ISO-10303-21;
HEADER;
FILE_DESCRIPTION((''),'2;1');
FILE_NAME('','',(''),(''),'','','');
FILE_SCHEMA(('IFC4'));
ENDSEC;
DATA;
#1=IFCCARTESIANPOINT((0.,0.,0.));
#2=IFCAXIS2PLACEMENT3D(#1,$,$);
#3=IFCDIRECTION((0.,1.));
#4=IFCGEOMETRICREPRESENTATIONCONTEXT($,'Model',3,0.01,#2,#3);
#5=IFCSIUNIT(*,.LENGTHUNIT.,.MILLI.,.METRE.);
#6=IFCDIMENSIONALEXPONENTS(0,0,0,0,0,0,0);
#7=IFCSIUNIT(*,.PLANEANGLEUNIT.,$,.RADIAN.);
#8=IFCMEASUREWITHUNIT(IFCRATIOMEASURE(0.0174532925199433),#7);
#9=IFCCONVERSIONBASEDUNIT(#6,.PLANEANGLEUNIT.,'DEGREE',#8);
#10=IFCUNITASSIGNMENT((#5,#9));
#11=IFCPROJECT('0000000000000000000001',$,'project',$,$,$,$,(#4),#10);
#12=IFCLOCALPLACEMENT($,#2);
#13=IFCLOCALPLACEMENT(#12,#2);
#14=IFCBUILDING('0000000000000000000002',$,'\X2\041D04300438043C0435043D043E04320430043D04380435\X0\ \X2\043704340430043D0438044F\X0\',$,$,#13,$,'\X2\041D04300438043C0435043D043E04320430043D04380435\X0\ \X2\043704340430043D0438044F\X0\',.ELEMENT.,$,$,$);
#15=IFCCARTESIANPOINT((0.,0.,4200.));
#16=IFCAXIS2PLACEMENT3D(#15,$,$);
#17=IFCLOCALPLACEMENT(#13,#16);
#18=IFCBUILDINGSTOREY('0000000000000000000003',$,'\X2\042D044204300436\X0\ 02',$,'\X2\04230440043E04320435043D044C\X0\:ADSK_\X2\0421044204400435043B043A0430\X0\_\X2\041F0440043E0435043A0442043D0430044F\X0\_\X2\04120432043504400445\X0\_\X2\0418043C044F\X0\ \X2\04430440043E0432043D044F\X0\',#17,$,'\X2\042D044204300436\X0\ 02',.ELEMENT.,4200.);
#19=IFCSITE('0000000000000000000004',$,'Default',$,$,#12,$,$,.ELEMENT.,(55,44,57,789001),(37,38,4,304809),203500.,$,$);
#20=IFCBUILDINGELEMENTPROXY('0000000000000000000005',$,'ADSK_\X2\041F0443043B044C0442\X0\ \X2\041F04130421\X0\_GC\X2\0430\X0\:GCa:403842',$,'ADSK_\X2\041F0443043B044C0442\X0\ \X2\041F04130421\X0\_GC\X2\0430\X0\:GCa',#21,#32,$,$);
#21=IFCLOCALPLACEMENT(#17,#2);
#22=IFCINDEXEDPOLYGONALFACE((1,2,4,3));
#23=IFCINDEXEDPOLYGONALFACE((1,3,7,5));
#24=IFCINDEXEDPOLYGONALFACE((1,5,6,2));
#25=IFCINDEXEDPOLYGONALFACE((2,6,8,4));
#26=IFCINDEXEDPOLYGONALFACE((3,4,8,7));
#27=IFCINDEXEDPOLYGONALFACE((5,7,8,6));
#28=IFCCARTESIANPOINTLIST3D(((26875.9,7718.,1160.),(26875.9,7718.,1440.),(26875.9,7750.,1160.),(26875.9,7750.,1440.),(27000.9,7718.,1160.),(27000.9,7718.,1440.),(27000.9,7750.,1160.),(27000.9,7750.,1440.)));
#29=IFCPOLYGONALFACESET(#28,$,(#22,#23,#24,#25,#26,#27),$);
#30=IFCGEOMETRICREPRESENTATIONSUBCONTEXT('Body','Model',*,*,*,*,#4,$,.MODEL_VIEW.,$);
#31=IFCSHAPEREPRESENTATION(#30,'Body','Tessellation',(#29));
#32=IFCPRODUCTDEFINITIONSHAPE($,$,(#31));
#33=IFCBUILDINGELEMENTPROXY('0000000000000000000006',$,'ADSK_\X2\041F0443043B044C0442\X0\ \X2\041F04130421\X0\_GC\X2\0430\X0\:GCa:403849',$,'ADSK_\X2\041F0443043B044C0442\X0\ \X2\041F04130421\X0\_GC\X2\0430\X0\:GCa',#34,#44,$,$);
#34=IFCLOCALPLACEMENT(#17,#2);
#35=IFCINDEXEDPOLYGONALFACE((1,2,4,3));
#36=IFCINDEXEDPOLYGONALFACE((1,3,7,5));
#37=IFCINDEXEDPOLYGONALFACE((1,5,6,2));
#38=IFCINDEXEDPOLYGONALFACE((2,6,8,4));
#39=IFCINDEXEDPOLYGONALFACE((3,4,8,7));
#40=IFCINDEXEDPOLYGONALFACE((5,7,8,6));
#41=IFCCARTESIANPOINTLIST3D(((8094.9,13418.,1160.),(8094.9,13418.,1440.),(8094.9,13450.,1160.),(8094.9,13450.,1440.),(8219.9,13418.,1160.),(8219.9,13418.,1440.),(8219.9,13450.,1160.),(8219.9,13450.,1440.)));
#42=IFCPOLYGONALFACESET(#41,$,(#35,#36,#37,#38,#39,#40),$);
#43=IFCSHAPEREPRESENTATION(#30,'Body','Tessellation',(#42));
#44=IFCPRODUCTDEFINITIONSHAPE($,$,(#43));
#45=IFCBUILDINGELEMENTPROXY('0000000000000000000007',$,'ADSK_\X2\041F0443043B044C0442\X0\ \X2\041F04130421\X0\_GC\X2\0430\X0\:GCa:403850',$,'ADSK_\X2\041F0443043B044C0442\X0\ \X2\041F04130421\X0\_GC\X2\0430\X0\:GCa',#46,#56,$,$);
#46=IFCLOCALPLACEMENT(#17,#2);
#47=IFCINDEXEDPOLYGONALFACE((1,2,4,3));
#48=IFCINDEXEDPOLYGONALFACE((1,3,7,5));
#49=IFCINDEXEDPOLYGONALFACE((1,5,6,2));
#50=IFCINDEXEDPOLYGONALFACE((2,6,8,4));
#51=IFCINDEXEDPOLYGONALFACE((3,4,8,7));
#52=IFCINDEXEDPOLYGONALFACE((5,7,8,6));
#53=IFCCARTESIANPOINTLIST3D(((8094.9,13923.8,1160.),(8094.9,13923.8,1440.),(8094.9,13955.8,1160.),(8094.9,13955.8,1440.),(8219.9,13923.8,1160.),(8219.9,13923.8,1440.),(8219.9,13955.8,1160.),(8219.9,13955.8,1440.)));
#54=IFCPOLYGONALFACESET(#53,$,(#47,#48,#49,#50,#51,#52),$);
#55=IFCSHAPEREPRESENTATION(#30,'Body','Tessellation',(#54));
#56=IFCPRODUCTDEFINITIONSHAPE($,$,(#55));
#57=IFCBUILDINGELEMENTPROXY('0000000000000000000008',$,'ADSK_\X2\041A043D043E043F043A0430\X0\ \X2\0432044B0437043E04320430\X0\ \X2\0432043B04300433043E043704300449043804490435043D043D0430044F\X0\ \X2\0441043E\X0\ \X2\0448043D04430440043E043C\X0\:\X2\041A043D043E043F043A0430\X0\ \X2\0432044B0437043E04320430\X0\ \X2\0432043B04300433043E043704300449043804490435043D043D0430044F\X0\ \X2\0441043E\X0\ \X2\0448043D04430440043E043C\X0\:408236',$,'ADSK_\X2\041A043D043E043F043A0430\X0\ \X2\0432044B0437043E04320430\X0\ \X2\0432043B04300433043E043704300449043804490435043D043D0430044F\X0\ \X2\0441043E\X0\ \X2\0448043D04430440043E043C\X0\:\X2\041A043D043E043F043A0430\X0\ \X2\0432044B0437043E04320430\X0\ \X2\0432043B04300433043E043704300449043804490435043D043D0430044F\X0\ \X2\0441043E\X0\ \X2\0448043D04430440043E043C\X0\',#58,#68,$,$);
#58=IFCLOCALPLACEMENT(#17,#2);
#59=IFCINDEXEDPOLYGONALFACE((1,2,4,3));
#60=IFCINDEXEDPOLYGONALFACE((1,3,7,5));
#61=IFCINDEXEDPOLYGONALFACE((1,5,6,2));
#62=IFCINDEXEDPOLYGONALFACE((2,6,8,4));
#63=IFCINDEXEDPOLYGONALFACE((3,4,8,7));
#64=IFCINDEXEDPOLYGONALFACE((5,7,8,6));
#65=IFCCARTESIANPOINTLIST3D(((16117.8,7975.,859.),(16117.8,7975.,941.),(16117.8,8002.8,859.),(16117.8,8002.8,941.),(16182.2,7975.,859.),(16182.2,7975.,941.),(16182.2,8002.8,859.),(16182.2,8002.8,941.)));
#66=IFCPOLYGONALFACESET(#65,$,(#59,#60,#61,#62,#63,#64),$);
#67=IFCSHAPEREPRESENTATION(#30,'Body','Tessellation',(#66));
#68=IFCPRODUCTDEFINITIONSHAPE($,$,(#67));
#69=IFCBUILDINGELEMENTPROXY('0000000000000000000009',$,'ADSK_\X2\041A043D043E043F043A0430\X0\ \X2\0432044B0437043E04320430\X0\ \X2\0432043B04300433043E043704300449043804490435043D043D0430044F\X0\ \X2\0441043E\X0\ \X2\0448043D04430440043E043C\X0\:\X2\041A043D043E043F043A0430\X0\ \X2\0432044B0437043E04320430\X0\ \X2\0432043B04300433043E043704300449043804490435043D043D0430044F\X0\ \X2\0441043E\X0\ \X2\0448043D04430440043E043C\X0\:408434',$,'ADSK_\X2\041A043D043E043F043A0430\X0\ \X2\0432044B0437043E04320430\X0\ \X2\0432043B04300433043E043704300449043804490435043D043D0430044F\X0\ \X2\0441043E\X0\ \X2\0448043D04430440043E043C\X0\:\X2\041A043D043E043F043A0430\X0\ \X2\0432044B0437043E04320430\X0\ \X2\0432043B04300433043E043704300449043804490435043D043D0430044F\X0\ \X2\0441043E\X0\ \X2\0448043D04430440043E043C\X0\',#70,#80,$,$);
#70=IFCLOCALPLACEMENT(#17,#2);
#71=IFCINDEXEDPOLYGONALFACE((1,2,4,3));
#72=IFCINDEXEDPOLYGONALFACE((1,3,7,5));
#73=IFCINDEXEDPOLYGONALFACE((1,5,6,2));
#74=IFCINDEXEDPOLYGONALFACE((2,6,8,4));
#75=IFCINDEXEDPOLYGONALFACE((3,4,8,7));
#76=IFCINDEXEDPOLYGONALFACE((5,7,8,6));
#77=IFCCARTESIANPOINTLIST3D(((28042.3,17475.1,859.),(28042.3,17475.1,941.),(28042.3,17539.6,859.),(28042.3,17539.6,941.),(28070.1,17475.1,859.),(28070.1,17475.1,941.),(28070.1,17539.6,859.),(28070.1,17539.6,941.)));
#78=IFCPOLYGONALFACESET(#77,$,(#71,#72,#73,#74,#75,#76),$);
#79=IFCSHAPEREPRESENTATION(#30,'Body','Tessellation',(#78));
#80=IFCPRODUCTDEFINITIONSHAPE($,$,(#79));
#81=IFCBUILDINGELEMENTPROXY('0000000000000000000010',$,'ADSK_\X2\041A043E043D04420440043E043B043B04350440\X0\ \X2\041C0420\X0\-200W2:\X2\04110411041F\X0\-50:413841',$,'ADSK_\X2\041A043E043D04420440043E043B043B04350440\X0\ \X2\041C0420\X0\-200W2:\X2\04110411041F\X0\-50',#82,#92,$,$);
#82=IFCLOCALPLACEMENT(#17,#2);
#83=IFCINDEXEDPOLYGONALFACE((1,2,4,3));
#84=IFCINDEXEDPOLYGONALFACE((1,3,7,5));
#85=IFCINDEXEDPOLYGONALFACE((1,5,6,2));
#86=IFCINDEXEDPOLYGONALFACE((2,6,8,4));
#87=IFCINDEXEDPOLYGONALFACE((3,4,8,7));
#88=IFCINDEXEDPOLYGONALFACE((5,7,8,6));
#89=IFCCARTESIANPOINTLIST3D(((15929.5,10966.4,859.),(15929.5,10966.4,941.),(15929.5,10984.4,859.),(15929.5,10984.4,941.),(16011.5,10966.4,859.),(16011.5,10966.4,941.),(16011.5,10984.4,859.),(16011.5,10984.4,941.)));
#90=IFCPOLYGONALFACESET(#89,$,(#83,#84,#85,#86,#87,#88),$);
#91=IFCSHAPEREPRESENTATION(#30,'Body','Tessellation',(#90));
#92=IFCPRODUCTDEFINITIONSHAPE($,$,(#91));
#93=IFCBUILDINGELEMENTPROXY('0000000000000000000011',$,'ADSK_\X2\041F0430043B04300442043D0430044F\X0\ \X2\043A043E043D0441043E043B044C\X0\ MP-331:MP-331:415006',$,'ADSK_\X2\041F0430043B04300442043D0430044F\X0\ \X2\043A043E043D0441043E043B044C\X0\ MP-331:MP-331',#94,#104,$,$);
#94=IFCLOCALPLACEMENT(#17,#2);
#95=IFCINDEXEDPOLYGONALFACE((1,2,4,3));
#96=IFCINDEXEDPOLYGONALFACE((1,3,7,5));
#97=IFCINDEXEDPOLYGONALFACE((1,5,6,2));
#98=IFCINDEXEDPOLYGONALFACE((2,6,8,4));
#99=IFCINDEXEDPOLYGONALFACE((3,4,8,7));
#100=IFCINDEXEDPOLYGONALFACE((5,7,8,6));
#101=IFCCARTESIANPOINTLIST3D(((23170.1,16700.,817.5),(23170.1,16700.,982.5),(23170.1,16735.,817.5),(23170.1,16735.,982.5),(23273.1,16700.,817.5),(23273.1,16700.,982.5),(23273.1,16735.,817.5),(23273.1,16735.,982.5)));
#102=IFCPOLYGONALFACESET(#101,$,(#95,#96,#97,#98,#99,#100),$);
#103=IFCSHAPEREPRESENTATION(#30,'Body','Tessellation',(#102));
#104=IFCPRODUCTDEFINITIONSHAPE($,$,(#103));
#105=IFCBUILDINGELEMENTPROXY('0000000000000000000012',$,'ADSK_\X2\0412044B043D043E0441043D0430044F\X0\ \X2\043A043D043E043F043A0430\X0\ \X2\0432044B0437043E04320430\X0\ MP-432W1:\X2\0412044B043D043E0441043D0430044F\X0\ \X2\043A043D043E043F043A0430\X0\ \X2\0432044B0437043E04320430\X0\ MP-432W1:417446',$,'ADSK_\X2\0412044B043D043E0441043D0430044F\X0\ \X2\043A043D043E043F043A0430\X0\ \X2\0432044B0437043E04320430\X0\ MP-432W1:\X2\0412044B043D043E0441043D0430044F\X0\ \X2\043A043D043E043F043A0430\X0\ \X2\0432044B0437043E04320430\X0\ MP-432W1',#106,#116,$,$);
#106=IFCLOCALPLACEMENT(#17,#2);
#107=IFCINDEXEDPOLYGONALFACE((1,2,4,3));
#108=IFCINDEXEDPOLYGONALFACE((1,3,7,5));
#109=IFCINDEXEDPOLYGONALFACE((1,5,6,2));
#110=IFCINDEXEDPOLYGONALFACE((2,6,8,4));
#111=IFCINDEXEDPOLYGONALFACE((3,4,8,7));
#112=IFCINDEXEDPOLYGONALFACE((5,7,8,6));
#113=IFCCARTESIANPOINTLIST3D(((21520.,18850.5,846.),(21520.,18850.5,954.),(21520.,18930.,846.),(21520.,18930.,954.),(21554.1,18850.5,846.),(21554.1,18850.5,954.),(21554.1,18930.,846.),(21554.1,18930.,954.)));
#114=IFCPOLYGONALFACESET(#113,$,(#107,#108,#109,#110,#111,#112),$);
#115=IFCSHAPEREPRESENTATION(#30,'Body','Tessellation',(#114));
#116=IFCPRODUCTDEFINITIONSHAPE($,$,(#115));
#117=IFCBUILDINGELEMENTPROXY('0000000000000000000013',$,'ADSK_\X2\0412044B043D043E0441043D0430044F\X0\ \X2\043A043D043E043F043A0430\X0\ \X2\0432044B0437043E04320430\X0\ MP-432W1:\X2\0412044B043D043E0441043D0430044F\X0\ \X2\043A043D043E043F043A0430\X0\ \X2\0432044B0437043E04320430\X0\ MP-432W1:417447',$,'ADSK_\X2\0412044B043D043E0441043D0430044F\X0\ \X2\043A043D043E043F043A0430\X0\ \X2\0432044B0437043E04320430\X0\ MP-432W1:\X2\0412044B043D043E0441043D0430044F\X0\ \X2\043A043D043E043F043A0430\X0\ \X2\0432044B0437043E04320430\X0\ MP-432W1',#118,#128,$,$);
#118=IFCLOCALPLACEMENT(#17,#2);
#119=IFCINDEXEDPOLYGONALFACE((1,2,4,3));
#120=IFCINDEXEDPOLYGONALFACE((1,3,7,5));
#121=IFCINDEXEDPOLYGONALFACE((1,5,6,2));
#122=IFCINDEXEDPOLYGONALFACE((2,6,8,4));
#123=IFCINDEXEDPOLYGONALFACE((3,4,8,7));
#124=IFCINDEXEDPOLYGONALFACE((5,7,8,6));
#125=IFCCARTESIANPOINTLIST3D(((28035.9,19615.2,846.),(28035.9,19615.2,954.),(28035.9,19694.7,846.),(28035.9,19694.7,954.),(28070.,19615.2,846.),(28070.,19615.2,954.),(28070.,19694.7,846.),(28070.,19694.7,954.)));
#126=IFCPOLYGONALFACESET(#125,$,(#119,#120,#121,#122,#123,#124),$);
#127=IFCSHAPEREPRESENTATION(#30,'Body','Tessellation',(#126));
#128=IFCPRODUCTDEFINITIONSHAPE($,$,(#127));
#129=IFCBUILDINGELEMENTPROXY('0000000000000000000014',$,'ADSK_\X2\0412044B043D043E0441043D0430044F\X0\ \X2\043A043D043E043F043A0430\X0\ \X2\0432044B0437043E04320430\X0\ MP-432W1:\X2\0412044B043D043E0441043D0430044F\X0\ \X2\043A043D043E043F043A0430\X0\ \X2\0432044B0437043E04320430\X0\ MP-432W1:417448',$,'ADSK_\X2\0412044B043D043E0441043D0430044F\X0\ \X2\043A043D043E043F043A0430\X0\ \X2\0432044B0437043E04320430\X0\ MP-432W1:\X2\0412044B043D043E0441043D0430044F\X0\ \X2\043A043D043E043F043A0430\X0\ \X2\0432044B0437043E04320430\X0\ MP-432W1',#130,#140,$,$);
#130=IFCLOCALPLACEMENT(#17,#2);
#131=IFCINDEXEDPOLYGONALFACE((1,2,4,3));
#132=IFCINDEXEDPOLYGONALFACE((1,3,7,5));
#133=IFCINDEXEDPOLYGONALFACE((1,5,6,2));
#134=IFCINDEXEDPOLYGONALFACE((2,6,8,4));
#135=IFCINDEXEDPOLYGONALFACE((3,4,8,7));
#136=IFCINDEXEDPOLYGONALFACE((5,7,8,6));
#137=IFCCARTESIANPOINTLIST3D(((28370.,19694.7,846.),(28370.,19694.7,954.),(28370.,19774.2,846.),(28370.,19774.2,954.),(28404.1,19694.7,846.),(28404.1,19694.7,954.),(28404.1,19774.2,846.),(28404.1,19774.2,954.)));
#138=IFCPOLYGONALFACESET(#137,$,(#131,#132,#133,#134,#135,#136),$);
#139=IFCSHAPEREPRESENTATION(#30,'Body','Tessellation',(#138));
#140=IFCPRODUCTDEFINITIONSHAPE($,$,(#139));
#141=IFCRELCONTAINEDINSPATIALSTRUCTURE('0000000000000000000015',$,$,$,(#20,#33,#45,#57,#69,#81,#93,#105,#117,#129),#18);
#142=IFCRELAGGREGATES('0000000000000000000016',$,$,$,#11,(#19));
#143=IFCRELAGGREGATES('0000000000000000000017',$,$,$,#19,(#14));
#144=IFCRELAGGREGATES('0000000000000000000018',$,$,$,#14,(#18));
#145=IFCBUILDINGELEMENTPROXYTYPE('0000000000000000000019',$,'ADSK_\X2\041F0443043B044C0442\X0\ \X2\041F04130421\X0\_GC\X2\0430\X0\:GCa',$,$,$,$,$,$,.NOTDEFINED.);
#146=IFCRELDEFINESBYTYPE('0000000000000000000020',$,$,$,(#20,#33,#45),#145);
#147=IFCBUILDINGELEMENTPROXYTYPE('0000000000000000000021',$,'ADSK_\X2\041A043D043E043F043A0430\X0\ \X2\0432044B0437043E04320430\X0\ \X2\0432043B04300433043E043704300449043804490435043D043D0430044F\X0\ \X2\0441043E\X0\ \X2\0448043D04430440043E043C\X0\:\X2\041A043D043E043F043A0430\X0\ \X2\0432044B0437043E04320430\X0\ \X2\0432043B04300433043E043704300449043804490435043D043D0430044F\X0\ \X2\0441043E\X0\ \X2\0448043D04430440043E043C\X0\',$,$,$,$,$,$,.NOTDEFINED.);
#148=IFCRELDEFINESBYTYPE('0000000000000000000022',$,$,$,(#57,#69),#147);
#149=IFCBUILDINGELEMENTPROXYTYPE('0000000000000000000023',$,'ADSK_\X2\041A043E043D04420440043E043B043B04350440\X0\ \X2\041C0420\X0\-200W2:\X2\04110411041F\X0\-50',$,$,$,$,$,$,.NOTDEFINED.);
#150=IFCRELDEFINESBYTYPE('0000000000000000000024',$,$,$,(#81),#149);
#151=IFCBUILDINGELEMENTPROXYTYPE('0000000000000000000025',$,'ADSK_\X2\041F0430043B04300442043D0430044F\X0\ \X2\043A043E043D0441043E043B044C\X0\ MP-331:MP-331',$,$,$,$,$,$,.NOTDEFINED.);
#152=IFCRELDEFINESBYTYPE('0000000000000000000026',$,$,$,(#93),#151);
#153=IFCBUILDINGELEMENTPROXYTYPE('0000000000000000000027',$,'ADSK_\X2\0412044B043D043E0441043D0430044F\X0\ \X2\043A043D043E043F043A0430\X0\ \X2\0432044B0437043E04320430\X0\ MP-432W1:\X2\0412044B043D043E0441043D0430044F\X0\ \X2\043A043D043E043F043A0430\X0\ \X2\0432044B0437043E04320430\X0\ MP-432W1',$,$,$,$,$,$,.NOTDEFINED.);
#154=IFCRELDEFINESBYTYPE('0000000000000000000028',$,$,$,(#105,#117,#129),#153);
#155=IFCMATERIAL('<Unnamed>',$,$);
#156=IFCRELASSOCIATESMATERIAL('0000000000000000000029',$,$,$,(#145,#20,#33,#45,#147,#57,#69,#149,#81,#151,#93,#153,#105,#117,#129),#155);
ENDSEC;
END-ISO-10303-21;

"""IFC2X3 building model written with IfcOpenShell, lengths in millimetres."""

from ifc_helpers import new_model, entity, si_unit, converted_unit, direction, frame, origin, origin_2d_with_axis, place, context, subcontext, project, spatial, rectangle, extrude, source, transform, mapped, material, type_object, type_shapes, element, save


model = new_model("IFC2X3")

# Units and contexts
model_context = context("Model", 3, precision=0.01, world=origin(), true_north=direction((0.0, 1.0)))
body_context = subcontext(model_context, "Body", "Model", "MODEL_VIEW")
ifc_project = project(units=[si_unit("LENGTHUNIT", "METRE", prefix="MILLI"), converted_unit("PLANEANGLEUNIT", "DEGREE", entity("IfcRatioMeasure", 0.0174532925199433), si_unit("PLANEANGLEUNIT", "RADIAN"), dimensions=[0, 0, 0, 0, 0, 0, 0])], contexts=[model_context])

# Site, building, storey
site_placement = place(None, origin())
site = spatial("IfcSite", under=ifc_project, at=site_placement, Name="Default", CompositionType="ELEMENT", RefLatitude=(55, 44, 57, 789001), RefLongitude=(37, 38, 4, 304809), RefElevation=203500.0)
building_placement = place(site_placement, origin())
building = spatial("IfcBuilding", under=site, at=building_placement, Name="Наименование здания", LongName="Наименование здания", CompositionType="ELEMENT")
storey_placement = place(building_placement, frame((0.0, 0.0, 4200.0)))
storey = spatial("IfcBuildingStorey", under=building, at=storey_placement, Name="Этаж 02", ObjectType="Уровень:ADSK_Стрелка_Проектная_Вверх_Имя уровня", LongName="Этаж 02", CompositionType="ELEMENT", Elevation=4200.0)

# Building element proxies
ifc_material_1 = material(Name="<Unnamed>")
building_element_proxy_type_1 = type_object("IfcBuildingElementProxyType", Name="ADSK_Пульт ПГС_GCа:GCa", PredefinedType="NOTDEFINED", material=ifc_material_1)
shared_shape_1 = source(origin(), body_context, "Body", "SweptSolid", [
    extrude(rectangle(XDim=125.0, YDim=32.0, at=origin_2d_with_axis()), frame((0.0, 16.0, -140.0), z_axis=(0.0, 0.0, 1.0), x_axis=(-1.0, 0.0, 0.0)), (0.0, 0.0, 1.0), 280.0),
])
type_shapes(building_element_proxy_type_1, [shared_shape_1])
for number, where, name in (
    (1, (26938.4, 7718.0, 1300.0), "ADSK_Пульт ПГС_GCа:GCa:403842"),
    (2, (8157.4, 13418.0, 1300.0), "ADSK_Пульт ПГС_GCа:GCa:403849"),
    (3, (8157.4, 13923.8, 1300.0), "ADSK_Пульт ПГС_GCа:GCa:403850"),
):
    element("IfcBuildingElementProxy", number, at=place(storey_placement, frame(where)), inside=storey, type_object=building_element_proxy_type_1, material=ifc_material_1, Name=name, ObjectType="ADSK_Пульт ПГС_GCа:GCa", context=body_context, shape_type="MappedRepresentation", body=[
        mapped(shared_shape_1, transform((0.0, 0.0, 0.0), scale=1.0)),
    ])
building_element_proxy_type_2 = type_object("IfcBuildingElementProxyType", Name="ADSK_Кнопка вызова влагозащищенная со шнуром:Кнопка вызова влагозащищенная со шнуром", PredefinedType="NOTDEFINED", material=ifc_material_1)
shared_shape_2 = source(origin(), body_context, "Body", "SweptSolid", [
    extrude(rectangle(XDim=64.5, YDim=27.8, at=origin_2d_with_axis()), frame((32.2, 13.9, 0.0), z_axis=(0.0, 0.0, 1.0), x_axis=(-1.0, 0.0, 0.0)), (0.0, 0.0, 1.0), 82.0),
])
type_shapes(building_element_proxy_type_2, [shared_shape_2])
for number, where, z_axis, x_axis, name in (
    (4, (16182.2, 8002.8, 859.0), (0.0, 0.0, 1.0), (-1.0, 0.0, 0.0), "ADSK_Кнопка вызова влагозащищенная со шнуром:Кнопка вызова влагозащищенная со шнуром:408236"),
    (5, (28042.3, 17539.6, 859.0), (0.0, 0.0, 1.0), (0.0, -1.0, 0.0), "ADSK_Кнопка вызова влагозащищенная со шнуром:Кнопка вызова влагозащищенная со шнуром:408434"),
):
    element("IfcBuildingElementProxy", number, at=place(storey_placement, frame(where, z_axis=z_axis, x_axis=x_axis)), inside=storey, type_object=building_element_proxy_type_2, material=ifc_material_1, Name=name, ObjectType="ADSK_Кнопка вызова влагозащищенная со шнуром:Кнопка вызова влагозащищенная со шнуром", context=body_context, shape_type="MappedRepresentation", body=[
        mapped(shared_shape_2, transform((0.0, 0.0, 0.0), scale=1.0)),
    ])
building_element_proxy_type_3 = type_object("IfcBuildingElementProxyType", Name="ADSK_Контроллер МР-200W2:ББП-50", PredefinedType="NOTDEFINED", material=ifc_material_1)
shared_shape_3 = source(origin(), body_context, "Body", "SweptSolid", [
    extrude(rectangle(XDim=82.0, YDim=18.0, at=origin_2d_with_axis()), frame((41.0, 9.0, 0.0), z_axis=(0.0, 0.0, 1.0), x_axis=(-1.0, 0.0, 0.0)), (0.0, 0.0, 1.0), 82.0),
])
type_shapes(building_element_proxy_type_3, [shared_shape_3])
proxy_1_placement = place(storey_placement, frame((15929.5, 10966.4, 859.0)))
element("IfcBuildingElementProxy", 6, at=proxy_1_placement, inside=storey, type_object=building_element_proxy_type_3, material=ifc_material_1, Name="ADSK_Контроллер МР-200W2:ББП-50:413841", ObjectType="ADSK_Контроллер МР-200W2:ББП-50", context=body_context, shape_type="MappedRepresentation", body=[
    mapped(shared_shape_3, transform((0.0, 0.0, 0.0), scale=1.0)),
])
building_element_proxy_type_4 = type_object("IfcBuildingElementProxyType", Name="ADSK_Палатная консоль MP-331:MP-331", PredefinedType="NOTDEFINED", material=ifc_material_1)
shared_shape_4 = source(origin(), body_context, "Body", "SweptSolid", [
    extrude(rectangle(XDim=103.0, YDim=35.0, at=origin_2d_with_axis()), frame((0.0, 14.5, -82.5), z_axis=(0.0, 0.0, 1.0), x_axis=(-1.0, 0.0, 0.0)), (0.0, 0.0, 1.0), 165.0),
])
type_shapes(building_element_proxy_type_4, [shared_shape_4])
proxy_2_placement = place(storey_placement, frame((23221.6, 16732.0, 900.0), z_axis=(0.0, 0.0, 1.0), x_axis=(-1.0, 0.0, 0.0)))
element("IfcBuildingElementProxy", 7, at=proxy_2_placement, inside=storey, type_object=building_element_proxy_type_4, material=ifc_material_1, Name="ADSK_Палатная консоль MP-331:MP-331:415006", ObjectType="ADSK_Палатная консоль MP-331:MP-331", context=body_context, shape_type="MappedRepresentation", body=[
    mapped(shared_shape_4, transform((0.0, 0.0, 0.0), scale=1.0)),
])
building_element_proxy_type_5 = type_object("IfcBuildingElementProxyType", Name="ADSK_Выносная кнопка вызова MP-432W1:Выносная кнопка вызова MP-432W1", PredefinedType="NOTDEFINED", material=ifc_material_1)
shared_shape_5 = source(origin(), body_context, "Body", "SweptSolid", [
    extrude(rectangle(XDim=79.5, YDim=34.1, at=origin_2d_with_axis()), frame((0.0, 15.0, -54.0), z_axis=(0.0, 0.0, 1.0), x_axis=(-1.0, 0.0, 0.0)), (0.0, 0.0, 1.0), 108.0),
])
type_shapes(building_element_proxy_type_5, [shared_shape_5])
for number, where, z_axis, x_axis, name in (
    (8, (21552.0, 18890.2, 900.0), (0.0, 0.0, 1.0), (0.0, 1.0, 0.0), "ADSK_Выносная кнопка вызова MP-432W1:Выносная кнопка вызова MP-432W1:417446"),
    (9, (28038.0, 19655.0, 900.0), (0.0, 0.0, 1.0), (0.0, -1.0, 0.0), "ADSK_Выносная кнопка вызова MP-432W1:Выносная кнопка вызова MP-432W1:417447"),
    (10, (28402.0, 19734.5, 900.0), (0.0, 0.0, 1.0), (0.0, 1.0, 0.0), "ADSK_Выносная кнопка вызова MP-432W1:Выносная кнопка вызова MP-432W1:417448"),
):
    element("IfcBuildingElementProxy", number, at=place(storey_placement, frame(where, z_axis=z_axis, x_axis=x_axis)), inside=storey, type_object=building_element_proxy_type_5, material=ifc_material_1, Name=name, ObjectType="ADSK_Выносная кнопка вызова MP-432W1:Выносная кнопка вызова MP-432W1", context=body_context, shape_type="MappedRepresentation", body=[
        mapped(shared_shape_5, transform((0.0, 0.0, 0.0), scale=1.0)),
    ])

save(model, "model.ifc")
